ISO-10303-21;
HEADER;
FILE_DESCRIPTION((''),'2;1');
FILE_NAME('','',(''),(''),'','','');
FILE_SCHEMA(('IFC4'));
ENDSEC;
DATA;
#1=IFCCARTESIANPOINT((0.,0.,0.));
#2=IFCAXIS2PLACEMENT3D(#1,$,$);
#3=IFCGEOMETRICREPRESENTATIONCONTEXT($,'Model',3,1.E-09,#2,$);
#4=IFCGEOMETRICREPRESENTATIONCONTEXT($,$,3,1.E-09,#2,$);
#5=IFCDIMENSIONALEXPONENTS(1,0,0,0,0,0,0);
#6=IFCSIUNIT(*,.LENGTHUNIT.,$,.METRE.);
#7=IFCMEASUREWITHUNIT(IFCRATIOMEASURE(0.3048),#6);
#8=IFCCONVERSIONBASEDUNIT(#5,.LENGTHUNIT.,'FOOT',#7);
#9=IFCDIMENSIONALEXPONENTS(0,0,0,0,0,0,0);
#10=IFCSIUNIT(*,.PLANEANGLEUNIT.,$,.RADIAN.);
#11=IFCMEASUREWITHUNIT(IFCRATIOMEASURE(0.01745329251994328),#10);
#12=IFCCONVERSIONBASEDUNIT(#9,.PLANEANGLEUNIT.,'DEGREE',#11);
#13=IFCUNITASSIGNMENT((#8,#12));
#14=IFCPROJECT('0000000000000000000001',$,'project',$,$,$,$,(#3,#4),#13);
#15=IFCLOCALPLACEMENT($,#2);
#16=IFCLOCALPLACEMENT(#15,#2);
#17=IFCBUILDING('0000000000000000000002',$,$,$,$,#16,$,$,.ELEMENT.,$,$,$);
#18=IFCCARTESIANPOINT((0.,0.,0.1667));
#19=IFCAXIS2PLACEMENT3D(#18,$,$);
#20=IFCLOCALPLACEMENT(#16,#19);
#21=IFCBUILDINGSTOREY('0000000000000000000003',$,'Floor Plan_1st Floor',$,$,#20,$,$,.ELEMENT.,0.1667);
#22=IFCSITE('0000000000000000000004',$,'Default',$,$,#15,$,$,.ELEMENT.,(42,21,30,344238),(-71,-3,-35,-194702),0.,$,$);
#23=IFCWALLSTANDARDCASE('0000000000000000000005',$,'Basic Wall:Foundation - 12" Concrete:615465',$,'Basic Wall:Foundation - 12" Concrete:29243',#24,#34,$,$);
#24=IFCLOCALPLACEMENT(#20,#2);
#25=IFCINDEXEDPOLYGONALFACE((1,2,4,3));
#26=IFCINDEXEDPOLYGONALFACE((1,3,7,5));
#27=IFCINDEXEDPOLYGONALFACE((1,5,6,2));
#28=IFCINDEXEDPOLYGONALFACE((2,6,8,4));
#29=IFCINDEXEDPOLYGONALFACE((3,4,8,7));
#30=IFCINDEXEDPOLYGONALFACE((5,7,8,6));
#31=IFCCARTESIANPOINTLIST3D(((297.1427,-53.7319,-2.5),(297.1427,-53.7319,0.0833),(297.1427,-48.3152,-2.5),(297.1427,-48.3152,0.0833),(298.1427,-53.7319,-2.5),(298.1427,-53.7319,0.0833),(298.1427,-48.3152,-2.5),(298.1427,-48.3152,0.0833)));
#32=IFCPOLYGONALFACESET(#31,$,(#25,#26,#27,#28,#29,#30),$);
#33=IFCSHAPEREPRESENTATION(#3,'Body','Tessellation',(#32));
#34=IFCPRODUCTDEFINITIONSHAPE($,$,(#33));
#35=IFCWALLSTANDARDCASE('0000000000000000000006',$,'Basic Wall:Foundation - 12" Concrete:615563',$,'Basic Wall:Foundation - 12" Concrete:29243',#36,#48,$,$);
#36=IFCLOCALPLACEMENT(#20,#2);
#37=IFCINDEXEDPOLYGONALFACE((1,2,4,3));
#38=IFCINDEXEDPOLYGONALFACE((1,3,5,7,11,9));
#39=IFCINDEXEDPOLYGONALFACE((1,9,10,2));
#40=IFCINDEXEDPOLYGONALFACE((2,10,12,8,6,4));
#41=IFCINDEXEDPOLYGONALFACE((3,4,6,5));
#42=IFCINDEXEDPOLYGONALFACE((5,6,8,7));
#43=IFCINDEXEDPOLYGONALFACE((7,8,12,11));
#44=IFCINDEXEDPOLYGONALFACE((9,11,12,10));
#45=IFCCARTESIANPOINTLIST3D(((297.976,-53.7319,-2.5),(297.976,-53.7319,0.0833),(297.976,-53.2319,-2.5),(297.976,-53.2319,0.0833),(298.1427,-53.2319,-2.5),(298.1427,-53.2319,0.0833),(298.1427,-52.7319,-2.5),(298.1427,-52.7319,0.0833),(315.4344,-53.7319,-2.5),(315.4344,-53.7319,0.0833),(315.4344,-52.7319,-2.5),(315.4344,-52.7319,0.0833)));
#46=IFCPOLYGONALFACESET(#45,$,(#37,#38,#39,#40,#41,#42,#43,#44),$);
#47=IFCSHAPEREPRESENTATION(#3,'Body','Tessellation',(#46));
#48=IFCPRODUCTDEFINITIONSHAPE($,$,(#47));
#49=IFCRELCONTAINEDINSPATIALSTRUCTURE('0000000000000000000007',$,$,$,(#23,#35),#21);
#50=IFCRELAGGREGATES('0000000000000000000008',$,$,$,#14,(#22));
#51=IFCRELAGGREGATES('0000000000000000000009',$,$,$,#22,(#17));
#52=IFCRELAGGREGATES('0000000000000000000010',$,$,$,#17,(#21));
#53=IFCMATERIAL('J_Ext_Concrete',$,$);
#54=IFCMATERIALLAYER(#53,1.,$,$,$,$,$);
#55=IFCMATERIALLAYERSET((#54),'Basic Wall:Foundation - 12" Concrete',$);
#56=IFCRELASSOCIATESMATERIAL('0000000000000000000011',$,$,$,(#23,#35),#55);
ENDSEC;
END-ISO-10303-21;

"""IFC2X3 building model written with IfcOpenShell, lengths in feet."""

from ifc_helpers import new_model, entity, si_unit, converted_unit, frame, frame_2d, origin, place, context, project, spatial, polyline, rectangle, outline, extrude, material, layer, layer_set, layer_usage, element, save


model = new_model("IFC2X3")

# Units and contexts
model_context = context("Model", 3, precision=1e-09, world=origin())
context_of_model = context(None, 3, precision=1e-09, world=origin())
ifc_project = project(units=[converted_unit("LENGTHUNIT", "FOOT", entity("IfcRatioMeasure", 0.3048), si_unit("LENGTHUNIT", "METRE"), dimensions=[1, 0, 0, 0, 0, 0, 0]), converted_unit("PLANEANGLEUNIT", "DEGREE", entity("IfcRatioMeasure", 0.01745329251994328), si_unit("PLANEANGLEUNIT", "RADIAN"), dimensions=[0, 0, 0, 0, 0, 0, 0])], contexts=[model_context, context_of_model])

# Site, building, storey
site_placement = place(None, origin())
site = spatial("IfcSite", under=ifc_project, at=site_placement, Name="Default", CompositionType="ELEMENT", RefLatitude=(42, 21, 30, 344238), RefLongitude=(-71, -3, -35, -194702), RefElevation=0.0)
building_placement = place(site_placement, origin())
building = spatial("IfcBuilding", under=site, at=building_placement, CompositionType="ELEMENT")
storey_placement = place(building_placement, frame((0.0, 0.0, 0.1667)))
storey = spatial("IfcBuildingStorey", under=building, at=storey_placement, Name="Floor Plan_1st Floor", CompositionType="ELEMENT", Elevation=0.1667)

# Shared definitions
ifc_material_1 = material(Name="J_Ext_Concrete")

# Walls
ifc_layer_1 = layer(ifc_material_1, 1.0)
ifc_layer_set_1 = layer_set([ifc_layer_1], Name="Basic Wall:Foundation - 12\" Concrete")
ifc_layer_usage_1 = layer_usage(ifc_layer_set_1, "AXIS2", "NEGATIVE", 0.5)
wall_1_placement = place(storey_placement, frame((297.6427, -48.3152, -2.5), z_axis=(0.0, 0.0, 1.0), x_axis=(0.0, -1.0, 0.0)))
element("IfcWallStandardCase", 1, at=wall_1_placement, inside=storey, material=ifc_layer_usage_1, Name="Basic Wall:Foundation - 12\" Concrete:615465", ObjectType="Basic Wall:Foundation - 12\" Concrete:29243", context=model_context, shape_type="SweptSolid", body=[
    extrude(rectangle(XDim=5.4167, YDim=1.0, at=frame_2d((2.7083, 0.0), x_axis=(-1.0, 0.0))), origin(), (0.0, 0.0, 1.0), 2.5833),
])
ifc_layer_usage_2 = layer_usage(ifc_layer_set_1, "AXIS2", "NEGATIVE", 0.5)
wall_2_placement = place(storey_placement, frame((297.976, -53.2319, -2.5)))
element("IfcWallStandardCase", 2, at=wall_2_placement, inside=storey, material=ifc_layer_usage_2, Name="Basic Wall:Foundation - 12\" Concrete:615563", ObjectType="Basic Wall:Foundation - 12\" Concrete:29243", context=model_context, shape_type="SweptSolid", body=[
    extrude(outline(polyline([(17.4583, -0.5), (17.4583, 0.5), (0.1667, 0.5), (0.1667, 0.0), (0.0, 0.0), (0.0, -0.5), (17.4583, -0.5)])), origin(), (0.0, 0.0, 1.0), 2.5833),
])

save(model, "model.ifc")
